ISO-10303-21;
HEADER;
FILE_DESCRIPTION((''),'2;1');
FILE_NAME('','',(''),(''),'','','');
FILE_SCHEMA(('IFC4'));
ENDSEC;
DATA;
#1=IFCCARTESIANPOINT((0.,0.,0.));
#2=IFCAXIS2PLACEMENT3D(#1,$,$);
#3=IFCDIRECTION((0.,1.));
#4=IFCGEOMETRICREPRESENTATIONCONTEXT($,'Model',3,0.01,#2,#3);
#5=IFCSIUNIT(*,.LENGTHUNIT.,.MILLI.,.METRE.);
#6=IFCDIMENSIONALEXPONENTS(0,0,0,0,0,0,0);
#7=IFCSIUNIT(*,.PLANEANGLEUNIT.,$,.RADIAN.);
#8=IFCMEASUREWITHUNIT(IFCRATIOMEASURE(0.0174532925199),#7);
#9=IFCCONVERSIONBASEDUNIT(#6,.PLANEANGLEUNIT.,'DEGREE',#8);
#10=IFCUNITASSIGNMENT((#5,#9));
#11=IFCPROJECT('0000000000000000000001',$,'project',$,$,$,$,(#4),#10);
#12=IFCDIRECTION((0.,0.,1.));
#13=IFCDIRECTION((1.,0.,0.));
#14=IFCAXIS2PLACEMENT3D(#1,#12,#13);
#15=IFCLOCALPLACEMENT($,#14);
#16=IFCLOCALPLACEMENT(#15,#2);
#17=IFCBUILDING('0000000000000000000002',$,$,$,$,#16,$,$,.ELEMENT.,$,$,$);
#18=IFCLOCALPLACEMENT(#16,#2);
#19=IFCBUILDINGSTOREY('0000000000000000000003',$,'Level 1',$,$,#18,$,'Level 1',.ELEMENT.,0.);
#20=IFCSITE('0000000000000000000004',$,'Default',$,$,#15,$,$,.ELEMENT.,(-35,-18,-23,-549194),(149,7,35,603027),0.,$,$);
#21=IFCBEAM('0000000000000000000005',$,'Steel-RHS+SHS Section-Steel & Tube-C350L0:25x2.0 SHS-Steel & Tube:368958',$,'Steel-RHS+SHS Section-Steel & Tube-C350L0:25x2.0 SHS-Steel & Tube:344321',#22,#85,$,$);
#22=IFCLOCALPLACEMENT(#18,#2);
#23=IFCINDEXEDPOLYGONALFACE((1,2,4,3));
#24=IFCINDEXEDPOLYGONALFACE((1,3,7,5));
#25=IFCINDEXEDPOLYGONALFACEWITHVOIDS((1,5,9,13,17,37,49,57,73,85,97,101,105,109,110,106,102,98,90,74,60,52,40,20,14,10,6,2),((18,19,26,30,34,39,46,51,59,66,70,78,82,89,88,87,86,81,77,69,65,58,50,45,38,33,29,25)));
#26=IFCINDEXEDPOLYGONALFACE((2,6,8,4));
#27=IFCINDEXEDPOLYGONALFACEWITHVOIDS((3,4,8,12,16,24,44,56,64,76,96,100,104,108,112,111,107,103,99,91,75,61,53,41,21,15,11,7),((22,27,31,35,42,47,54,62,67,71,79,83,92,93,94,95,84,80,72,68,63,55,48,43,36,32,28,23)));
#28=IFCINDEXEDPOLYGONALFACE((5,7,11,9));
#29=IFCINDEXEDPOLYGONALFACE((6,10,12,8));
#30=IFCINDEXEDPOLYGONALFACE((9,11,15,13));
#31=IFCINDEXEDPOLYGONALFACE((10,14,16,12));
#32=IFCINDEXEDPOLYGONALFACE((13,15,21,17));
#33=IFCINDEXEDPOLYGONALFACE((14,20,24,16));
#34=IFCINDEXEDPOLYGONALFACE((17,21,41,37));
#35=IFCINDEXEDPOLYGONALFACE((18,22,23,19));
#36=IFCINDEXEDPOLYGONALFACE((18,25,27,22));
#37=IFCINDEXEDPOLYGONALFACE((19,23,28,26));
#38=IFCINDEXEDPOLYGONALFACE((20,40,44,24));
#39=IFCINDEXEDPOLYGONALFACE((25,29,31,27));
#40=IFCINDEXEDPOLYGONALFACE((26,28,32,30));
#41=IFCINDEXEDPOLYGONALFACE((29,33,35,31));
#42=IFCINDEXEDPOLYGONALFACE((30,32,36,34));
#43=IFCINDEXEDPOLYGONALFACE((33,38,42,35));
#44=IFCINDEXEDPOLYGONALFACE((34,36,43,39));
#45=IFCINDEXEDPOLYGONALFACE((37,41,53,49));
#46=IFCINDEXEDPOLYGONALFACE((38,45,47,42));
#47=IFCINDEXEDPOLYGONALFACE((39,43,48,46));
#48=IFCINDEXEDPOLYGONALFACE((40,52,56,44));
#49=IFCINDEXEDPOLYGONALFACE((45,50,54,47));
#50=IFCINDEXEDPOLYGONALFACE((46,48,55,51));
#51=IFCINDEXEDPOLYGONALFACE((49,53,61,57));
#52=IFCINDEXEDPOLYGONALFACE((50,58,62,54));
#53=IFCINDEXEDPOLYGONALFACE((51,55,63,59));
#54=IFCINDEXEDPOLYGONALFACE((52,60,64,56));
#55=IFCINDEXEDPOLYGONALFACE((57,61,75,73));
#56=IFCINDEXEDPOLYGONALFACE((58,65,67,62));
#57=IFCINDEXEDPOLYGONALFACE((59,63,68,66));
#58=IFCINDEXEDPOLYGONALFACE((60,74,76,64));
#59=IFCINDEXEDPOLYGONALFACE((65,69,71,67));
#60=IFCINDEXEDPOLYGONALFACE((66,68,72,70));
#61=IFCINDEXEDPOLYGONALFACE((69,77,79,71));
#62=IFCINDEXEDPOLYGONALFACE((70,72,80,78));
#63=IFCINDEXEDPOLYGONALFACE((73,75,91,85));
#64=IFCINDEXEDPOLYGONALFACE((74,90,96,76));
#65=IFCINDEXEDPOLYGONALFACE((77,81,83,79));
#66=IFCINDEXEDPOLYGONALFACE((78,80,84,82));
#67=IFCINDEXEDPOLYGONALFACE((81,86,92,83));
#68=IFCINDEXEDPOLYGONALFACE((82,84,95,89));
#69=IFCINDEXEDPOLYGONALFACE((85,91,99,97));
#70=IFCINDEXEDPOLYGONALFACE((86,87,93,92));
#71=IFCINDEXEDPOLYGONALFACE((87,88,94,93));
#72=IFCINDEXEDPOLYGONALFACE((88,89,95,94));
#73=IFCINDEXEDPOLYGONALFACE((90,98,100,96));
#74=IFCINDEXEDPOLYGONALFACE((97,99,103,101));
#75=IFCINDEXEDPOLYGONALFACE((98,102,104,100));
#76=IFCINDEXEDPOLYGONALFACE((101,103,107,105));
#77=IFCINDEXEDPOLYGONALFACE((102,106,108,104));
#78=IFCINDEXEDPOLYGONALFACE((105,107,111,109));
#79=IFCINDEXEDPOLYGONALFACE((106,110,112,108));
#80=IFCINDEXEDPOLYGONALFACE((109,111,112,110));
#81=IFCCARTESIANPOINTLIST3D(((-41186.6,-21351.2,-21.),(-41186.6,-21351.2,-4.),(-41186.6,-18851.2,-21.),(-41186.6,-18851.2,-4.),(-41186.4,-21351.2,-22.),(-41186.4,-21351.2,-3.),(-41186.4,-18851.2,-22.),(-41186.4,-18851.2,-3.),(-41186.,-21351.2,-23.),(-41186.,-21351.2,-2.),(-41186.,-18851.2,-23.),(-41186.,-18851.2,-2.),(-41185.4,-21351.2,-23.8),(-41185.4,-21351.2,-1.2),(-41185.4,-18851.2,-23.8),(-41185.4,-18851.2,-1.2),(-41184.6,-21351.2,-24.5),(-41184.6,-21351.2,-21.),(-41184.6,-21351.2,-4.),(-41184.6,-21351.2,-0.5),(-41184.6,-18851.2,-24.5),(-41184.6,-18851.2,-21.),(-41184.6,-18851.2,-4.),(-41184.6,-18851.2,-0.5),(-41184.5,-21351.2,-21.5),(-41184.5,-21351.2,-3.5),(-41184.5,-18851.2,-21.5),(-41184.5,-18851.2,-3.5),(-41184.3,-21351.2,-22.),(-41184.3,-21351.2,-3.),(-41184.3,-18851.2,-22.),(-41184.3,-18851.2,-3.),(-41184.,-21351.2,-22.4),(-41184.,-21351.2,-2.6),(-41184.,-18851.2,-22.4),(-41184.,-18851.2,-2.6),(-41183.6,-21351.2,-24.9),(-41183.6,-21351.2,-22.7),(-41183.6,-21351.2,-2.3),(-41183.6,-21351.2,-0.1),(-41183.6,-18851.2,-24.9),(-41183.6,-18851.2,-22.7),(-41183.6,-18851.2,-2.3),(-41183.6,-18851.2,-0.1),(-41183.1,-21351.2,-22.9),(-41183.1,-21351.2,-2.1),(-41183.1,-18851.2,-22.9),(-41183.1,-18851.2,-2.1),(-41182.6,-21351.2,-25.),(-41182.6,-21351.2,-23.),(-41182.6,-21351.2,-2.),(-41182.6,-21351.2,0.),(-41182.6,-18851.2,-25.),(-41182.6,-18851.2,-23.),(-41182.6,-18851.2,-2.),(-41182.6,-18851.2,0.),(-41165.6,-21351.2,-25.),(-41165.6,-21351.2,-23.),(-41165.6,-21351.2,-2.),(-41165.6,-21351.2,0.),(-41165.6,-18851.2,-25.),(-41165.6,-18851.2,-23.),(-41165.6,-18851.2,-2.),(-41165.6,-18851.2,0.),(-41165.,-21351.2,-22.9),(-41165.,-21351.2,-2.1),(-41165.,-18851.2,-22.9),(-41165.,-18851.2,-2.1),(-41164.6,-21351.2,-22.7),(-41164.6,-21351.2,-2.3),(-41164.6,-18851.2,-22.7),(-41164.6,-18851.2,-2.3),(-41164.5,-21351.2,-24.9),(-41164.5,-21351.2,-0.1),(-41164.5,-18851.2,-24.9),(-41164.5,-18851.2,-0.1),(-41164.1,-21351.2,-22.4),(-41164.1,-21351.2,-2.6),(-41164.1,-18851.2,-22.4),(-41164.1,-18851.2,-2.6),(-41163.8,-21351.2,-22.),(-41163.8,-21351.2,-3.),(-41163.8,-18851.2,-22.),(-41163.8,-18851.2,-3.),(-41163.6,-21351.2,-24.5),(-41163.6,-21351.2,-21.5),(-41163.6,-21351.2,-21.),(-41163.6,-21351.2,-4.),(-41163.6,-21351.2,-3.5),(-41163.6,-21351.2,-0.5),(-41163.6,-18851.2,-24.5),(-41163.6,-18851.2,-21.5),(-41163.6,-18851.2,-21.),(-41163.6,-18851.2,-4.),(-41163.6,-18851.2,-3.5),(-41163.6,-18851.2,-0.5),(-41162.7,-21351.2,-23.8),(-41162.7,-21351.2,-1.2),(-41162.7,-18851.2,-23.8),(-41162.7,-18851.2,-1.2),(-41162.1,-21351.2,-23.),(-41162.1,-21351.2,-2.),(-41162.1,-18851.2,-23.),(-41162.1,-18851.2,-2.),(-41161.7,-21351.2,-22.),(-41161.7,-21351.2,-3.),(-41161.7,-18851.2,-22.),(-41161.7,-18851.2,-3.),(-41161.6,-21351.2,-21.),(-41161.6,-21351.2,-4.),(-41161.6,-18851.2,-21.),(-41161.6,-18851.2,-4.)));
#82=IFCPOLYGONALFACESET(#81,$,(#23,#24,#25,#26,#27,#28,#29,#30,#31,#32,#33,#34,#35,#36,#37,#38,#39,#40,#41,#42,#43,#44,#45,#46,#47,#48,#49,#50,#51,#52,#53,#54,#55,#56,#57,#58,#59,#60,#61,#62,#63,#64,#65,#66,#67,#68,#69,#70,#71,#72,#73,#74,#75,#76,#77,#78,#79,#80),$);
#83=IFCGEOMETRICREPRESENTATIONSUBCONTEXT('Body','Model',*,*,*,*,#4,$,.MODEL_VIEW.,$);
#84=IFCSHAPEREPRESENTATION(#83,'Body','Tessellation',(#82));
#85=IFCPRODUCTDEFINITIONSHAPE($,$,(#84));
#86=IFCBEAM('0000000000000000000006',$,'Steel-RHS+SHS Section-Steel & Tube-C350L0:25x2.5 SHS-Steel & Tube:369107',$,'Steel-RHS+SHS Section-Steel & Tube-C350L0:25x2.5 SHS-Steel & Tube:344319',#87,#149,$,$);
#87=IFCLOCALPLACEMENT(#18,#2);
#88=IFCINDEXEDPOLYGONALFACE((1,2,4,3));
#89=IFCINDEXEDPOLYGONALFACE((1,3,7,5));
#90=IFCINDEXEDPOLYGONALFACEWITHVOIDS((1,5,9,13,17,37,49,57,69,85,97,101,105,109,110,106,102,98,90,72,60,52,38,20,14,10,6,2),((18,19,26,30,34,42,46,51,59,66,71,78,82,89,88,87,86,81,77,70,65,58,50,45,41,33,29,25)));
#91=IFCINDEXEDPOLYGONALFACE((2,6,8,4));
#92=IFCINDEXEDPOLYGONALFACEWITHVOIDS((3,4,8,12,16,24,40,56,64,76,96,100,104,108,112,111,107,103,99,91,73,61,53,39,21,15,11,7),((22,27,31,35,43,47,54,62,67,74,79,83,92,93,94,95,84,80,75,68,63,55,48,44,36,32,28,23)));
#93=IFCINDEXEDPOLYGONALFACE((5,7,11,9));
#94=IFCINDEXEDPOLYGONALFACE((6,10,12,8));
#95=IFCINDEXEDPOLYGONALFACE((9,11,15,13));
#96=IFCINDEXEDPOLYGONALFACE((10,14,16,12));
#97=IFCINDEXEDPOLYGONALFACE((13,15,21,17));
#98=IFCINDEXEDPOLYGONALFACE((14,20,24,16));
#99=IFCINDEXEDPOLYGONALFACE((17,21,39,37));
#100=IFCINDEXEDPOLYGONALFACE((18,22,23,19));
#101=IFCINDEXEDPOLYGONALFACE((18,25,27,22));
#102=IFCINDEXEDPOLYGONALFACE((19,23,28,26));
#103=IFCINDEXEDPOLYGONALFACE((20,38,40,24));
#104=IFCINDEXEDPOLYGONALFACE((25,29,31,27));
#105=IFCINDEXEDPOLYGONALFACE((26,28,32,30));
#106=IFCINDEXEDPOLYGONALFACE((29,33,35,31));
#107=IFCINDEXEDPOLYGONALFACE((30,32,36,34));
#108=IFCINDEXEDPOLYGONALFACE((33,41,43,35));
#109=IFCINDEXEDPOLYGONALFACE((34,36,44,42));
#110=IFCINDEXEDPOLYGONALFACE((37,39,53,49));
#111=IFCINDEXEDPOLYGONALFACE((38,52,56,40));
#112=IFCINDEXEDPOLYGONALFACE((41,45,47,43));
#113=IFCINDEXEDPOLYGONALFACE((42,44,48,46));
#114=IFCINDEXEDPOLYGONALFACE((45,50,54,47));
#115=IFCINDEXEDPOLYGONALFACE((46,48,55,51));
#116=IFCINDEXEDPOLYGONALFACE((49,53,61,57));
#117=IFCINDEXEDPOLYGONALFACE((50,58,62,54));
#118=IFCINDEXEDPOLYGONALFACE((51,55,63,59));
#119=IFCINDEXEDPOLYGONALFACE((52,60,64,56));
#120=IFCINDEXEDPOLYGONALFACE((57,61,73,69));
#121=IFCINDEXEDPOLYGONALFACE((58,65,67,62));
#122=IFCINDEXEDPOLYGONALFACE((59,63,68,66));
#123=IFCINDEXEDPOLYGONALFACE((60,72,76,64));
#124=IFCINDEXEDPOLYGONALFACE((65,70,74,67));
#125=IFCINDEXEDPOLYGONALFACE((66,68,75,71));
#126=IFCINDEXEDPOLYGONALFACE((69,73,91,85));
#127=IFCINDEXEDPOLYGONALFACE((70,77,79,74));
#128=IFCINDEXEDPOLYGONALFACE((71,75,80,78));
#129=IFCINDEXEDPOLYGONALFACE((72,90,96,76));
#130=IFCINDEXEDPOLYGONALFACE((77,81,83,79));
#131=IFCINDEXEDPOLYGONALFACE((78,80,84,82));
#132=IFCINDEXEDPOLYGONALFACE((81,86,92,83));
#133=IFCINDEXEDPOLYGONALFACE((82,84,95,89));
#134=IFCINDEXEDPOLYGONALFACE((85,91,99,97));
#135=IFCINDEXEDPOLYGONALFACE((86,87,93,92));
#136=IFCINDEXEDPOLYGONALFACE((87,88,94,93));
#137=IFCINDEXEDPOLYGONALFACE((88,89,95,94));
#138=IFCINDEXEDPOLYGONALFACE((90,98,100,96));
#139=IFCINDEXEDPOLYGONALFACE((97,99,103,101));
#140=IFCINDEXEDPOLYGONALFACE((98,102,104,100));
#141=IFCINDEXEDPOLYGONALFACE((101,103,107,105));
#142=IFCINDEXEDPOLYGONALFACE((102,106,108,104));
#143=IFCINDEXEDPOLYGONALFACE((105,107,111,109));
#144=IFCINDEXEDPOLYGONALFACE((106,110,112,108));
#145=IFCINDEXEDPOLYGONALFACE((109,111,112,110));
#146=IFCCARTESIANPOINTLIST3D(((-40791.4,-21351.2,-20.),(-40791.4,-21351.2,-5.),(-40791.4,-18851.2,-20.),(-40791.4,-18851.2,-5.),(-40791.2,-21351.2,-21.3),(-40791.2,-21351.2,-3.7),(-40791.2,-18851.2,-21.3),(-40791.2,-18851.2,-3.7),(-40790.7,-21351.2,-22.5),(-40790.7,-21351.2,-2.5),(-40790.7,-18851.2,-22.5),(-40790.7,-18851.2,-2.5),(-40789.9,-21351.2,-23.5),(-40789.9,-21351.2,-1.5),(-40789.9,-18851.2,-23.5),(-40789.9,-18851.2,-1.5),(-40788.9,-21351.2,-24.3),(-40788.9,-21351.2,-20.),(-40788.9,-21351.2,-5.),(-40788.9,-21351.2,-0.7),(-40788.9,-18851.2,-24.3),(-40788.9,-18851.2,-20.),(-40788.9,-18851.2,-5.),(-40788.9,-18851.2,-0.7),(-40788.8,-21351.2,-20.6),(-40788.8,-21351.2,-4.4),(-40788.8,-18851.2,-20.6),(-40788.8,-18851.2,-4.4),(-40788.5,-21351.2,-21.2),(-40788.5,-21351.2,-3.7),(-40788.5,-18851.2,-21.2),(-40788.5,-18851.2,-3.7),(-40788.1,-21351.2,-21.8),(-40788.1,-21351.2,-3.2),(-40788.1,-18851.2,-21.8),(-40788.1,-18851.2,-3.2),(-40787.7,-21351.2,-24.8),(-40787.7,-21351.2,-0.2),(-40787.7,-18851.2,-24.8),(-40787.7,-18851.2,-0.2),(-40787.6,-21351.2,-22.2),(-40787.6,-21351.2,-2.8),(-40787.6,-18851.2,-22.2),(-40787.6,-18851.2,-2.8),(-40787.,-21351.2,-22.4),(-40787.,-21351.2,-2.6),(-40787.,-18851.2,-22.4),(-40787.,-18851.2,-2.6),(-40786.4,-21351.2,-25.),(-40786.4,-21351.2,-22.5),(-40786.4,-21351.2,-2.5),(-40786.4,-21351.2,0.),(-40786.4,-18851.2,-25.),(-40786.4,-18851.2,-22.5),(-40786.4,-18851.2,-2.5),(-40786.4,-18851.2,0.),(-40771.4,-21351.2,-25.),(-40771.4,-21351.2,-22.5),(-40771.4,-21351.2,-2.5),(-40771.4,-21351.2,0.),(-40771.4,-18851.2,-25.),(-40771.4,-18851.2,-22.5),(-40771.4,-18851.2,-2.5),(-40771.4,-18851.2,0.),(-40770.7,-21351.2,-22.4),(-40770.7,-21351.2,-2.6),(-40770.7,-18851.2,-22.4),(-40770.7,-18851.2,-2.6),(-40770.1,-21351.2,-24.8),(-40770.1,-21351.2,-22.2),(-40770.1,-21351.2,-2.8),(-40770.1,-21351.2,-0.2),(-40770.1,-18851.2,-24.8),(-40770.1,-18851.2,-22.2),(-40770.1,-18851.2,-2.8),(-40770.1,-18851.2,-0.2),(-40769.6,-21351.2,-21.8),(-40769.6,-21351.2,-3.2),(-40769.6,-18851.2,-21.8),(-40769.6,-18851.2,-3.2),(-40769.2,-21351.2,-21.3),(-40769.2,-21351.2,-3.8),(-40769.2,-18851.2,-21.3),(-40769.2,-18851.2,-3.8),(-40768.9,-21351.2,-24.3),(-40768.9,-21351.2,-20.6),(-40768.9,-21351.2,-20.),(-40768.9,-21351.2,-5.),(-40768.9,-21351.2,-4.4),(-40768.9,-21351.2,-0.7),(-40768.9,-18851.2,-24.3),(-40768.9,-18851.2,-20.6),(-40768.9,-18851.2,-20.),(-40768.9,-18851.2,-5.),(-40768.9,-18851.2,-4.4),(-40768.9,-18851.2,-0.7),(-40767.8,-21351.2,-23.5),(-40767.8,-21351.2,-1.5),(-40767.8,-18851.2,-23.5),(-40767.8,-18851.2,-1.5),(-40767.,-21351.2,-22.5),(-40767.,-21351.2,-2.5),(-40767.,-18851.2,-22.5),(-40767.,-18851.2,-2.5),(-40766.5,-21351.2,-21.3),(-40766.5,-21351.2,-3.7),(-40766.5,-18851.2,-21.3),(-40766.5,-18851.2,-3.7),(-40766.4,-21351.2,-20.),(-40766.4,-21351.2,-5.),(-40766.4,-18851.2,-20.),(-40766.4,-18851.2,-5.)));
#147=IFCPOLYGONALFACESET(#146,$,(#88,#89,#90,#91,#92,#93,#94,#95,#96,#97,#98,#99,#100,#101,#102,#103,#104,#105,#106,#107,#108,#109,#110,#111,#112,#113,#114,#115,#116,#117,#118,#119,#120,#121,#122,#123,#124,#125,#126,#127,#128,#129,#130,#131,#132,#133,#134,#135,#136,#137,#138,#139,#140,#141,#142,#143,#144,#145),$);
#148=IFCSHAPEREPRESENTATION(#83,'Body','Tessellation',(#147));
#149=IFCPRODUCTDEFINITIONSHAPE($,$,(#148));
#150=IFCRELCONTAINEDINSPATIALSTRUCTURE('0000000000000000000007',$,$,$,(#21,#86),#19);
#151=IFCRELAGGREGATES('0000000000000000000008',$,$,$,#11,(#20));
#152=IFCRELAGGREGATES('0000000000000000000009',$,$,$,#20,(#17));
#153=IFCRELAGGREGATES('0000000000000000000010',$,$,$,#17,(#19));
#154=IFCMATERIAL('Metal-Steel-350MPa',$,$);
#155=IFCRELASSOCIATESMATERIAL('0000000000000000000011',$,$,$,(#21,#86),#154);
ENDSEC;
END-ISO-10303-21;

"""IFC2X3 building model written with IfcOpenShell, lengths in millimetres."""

from ifc_helpers import new_model, entity, si_unit, converted_unit, direction, frame, frame_2d, origin, origin_with_axes, place, context, subcontext, project, spatial, polyline, circle_curve, parameter, trimmed, segment, composite_curve, outline, extrude, material, element, save


model = new_model("IFC2X3")

# Units and contexts
model_context = context("Model", 3, precision=0.01, world=origin(), true_north=direction((0.0, 1.0)))
body_context = subcontext(model_context, "Body", "Model", "MODEL_VIEW")
ifc_project = project(units=[si_unit("LENGTHUNIT", "METRE", prefix="MILLI"), converted_unit("PLANEANGLEUNIT", "DEGREE", entity("IfcRatioMeasure", 0.0174532925199), si_unit("PLANEANGLEUNIT", "RADIAN"), dimensions=[0, 0, 0, 0, 0, 0, 0])], contexts=[model_context])

# Site, building, storey
site_placement = place(None, origin_with_axes())
site = spatial("IfcSite", under=ifc_project, at=site_placement, Name="Default", CompositionType="ELEMENT", RefLatitude=(-35, -18, -23, -549194), RefLongitude=(149, 7, 35, 603027), RefElevation=0.0)
building_placement = place(site_placement, origin())
building = spatial("IfcBuilding", under=site, at=building_placement, CompositionType="ELEMENT")
storey_placement = place(building_placement, origin())
storey = spatial("IfcBuildingStorey", under=building, at=storey_placement, Name="Level 1", LongName="Level 1", CompositionType="ELEMENT", Elevation=0.0)

# Beams
ifc_material = material(Name="Metal-Steel-350MPa")
beam_1_placement = place(storey_placement, frame((-41174.1, -18851.2, 0.0), z_axis=(0.0, 0.0, 1.0), x_axis=(0.0, -1.0, 0.0)))
element("IfcBeam", 1, at=beam_1_placement, inside=storey, material=ifc_material, Name="Steel-RHS+SHS Section-Steel & Tube-C350L0:25x2.0 SHS-Steel & Tube:368958", ObjectType="Steel-RHS+SHS Section-Steel & Tube-C350L0:25x2.0 SHS-Steel & Tube:344321", context=body_context, shape_type="SweptSolid", body=[
    extrude(outline(composite_curve([segment(trimmed(circle_curve(frame_2d((-8.5, -8.5), x_axis=(1.0, 0.0)), 4.0), [parameter(180.0)], [parameter(270.0)], True, "PARAMETER"), True, "CONTINUOUS"), segment(polyline([(-8.5, -12.5), (8.5, -12.5)]), True, "CONTINUOUS"), segment(trimmed(circle_curve(frame_2d((8.5, -8.5), x_axis=(1.0, 0.0)), 4.0), [parameter(270.0)], [parameter(0.0)], True, "PARAMETER"), True, "CONTINUOUS"), segment(polyline([(12.5, -8.5), (12.5, 8.5)]), True, "CONTINUOUS"), segment(trimmed(circle_curve(frame_2d((8.5, 8.5), x_axis=(1.0, 0.0)), 4.0), [parameter(0.0)], [parameter(90.0)], True, "PARAMETER"), True, "CONTINUOUS"), segment(polyline([(8.5, 12.5), (-8.5, 12.5)]), True, "CONTINUOUS"), segment(trimmed(circle_curve(frame_2d((-8.5, 8.5), x_axis=(1.0, 0.0)), 4.0), [parameter(90.0)], [parameter(180.0)], True, "PARAMETER"), True, "CONTINUOUS"), segment(polyline([(-12.5, 8.5), (-12.5, -8.5)]), True, "CONTINUOUS")], self_intersect=False), holes=[composite_curve([segment(polyline([(8.5, -10.5), (-8.5, -10.5)]), True, "CONTINUOUS"), segment(trimmed(circle_curve(frame_2d((-8.5, -8.5), x_axis=(1.0, 0.0)), 2.0), [parameter(180.0)], [parameter(270.0)], True, "PARAMETER"), False, "CONTINUOUS"), segment(polyline([(-10.5, -8.5), (-10.5, 8.5)]), True, "CONTINUOUS"), segment(trimmed(circle_curve(frame_2d((-8.5, 8.5), x_axis=(1.0, 0.0)), 2.0), [parameter(90.0)], [parameter(180.0)], True, "PARAMETER"), False, "CONTINUOUS"), segment(polyline([(-8.5, 10.5), (8.5, 10.5)]), True, "CONTINUOUS"), segment(trimmed(circle_curve(frame_2d((8.5, 8.5), x_axis=(1.0, 0.0)), 2.0), [parameter(360.0)], [parameter(90.0)], True, "PARAMETER"), False, "CONTINUOUS"), segment(polyline([(10.5, 8.5), (10.5, -8.5)]), True, "CONTINUOUS"), segment(trimmed(circle_curve(frame_2d((8.5, -8.5), x_axis=(1.0, 0.0)), 2.0), [parameter(270.0)], [parameter(0.0)], True, "PARAMETER"), False, "CONTINUOUS")], self_intersect=False)]), frame((0.0, 0.0, -12.5), z_axis=(1.0, 0.0, 0.0), x_axis=(0.0, -1.0, 0.0)), (0.0, 0.0, 1.0), 2500.0),
])
beam_2_placement = place(storey_placement, frame((-40778.9, -18851.2, 0.0), z_axis=(0.0, 0.0, 1.0), x_axis=(0.0, -1.0, 0.0)))
element("IfcBeam", 2, at=beam_2_placement, inside=storey, material=ifc_material, Name="Steel-RHS+SHS Section-Steel & Tube-C350L0:25x2.5 SHS-Steel & Tube:369107", ObjectType="Steel-RHS+SHS Section-Steel & Tube-C350L0:25x2.5 SHS-Steel & Tube:344319", context=body_context, shape_type="SweptSolid", body=[
    extrude(outline(composite_curve([segment(trimmed(circle_curve(frame_2d((-7.5, -7.5), x_axis=(1.0, 0.0)), 5.0), [parameter(180.0)], [parameter(270.0)], True, "PARAMETER"), True, "CONTINUOUS"), segment(polyline([(-7.5, -12.5), (7.5, -12.5)]), True, "CONTINUOUS"), segment(trimmed(circle_curve(frame_2d((7.5, -7.5), x_axis=(1.0, 0.0)), 5.0), [parameter(270.0)], [parameter(0.0)], True, "PARAMETER"), True, "CONTINUOUS"), segment(polyline([(12.5, -7.5), (12.5, 7.5)]), True, "CONTINUOUS"), segment(trimmed(circle_curve(frame_2d((7.5, 7.5), x_axis=(1.0, 0.0)), 5.0), [parameter(0.0)], [parameter(90.0)], True, "PARAMETER"), True, "CONTINUOUS"), segment(polyline([(7.5, 12.5), (-7.5, 12.5)]), True, "CONTINUOUS"), segment(trimmed(circle_curve(frame_2d((-7.5, 7.5), x_axis=(1.0, 0.0)), 5.0), [parameter(90.0)], [parameter(180.0)], True, "PARAMETER"), True, "CONTINUOUS"), segment(polyline([(-12.5, 7.5), (-12.5, -7.5)]), True, "CONTINUOUS")], self_intersect=False), holes=[composite_curve([segment(polyline([(7.5, -10.0), (-7.5, -10.0)]), True, "CONTINUOUS"), segment(trimmed(circle_curve(frame_2d((-7.5, -7.5), x_axis=(1.0, 0.0)), 2.5), [parameter(180.0)], [parameter(270.0)], True, "PARAMETER"), False, "CONTINUOUS"), segment(polyline([(-10.0, -7.5), (-10.0, 7.5)]), True, "CONTINUOUS"), segment(trimmed(circle_curve(frame_2d((-7.5, 7.5), x_axis=(1.0, 0.0)), 2.5), [parameter(90.0)], [parameter(180.0)], True, "PARAMETER"), False, "CONTINUOUS"), segment(polyline([(-7.5, 10.0), (7.5, 10.0)]), True, "CONTINUOUS"), segment(trimmed(circle_curve(frame_2d((7.5, 7.5), x_axis=(1.0, 0.0)), 2.5), [parameter(360.0)], [parameter(90.0)], True, "PARAMETER"), False, "CONTINUOUS"), segment(polyline([(10.0, 7.5), (10.0, -7.5)]), True, "CONTINUOUS"), segment(trimmed(circle_curve(frame_2d((7.5, -7.5), x_axis=(1.0, 0.0)), 2.5), [parameter(270.0)], [parameter(0.0)], True, "PARAMETER"), False, "CONTINUOUS")], self_intersect=False)]), frame((0.0, 0.0, -12.5), z_axis=(1.0, 0.0, 0.0), x_axis=(0.0, -1.0, 0.0)), (0.0, 0.0, 1.0), 2500.0),
])

save(model, "model.ifc")
